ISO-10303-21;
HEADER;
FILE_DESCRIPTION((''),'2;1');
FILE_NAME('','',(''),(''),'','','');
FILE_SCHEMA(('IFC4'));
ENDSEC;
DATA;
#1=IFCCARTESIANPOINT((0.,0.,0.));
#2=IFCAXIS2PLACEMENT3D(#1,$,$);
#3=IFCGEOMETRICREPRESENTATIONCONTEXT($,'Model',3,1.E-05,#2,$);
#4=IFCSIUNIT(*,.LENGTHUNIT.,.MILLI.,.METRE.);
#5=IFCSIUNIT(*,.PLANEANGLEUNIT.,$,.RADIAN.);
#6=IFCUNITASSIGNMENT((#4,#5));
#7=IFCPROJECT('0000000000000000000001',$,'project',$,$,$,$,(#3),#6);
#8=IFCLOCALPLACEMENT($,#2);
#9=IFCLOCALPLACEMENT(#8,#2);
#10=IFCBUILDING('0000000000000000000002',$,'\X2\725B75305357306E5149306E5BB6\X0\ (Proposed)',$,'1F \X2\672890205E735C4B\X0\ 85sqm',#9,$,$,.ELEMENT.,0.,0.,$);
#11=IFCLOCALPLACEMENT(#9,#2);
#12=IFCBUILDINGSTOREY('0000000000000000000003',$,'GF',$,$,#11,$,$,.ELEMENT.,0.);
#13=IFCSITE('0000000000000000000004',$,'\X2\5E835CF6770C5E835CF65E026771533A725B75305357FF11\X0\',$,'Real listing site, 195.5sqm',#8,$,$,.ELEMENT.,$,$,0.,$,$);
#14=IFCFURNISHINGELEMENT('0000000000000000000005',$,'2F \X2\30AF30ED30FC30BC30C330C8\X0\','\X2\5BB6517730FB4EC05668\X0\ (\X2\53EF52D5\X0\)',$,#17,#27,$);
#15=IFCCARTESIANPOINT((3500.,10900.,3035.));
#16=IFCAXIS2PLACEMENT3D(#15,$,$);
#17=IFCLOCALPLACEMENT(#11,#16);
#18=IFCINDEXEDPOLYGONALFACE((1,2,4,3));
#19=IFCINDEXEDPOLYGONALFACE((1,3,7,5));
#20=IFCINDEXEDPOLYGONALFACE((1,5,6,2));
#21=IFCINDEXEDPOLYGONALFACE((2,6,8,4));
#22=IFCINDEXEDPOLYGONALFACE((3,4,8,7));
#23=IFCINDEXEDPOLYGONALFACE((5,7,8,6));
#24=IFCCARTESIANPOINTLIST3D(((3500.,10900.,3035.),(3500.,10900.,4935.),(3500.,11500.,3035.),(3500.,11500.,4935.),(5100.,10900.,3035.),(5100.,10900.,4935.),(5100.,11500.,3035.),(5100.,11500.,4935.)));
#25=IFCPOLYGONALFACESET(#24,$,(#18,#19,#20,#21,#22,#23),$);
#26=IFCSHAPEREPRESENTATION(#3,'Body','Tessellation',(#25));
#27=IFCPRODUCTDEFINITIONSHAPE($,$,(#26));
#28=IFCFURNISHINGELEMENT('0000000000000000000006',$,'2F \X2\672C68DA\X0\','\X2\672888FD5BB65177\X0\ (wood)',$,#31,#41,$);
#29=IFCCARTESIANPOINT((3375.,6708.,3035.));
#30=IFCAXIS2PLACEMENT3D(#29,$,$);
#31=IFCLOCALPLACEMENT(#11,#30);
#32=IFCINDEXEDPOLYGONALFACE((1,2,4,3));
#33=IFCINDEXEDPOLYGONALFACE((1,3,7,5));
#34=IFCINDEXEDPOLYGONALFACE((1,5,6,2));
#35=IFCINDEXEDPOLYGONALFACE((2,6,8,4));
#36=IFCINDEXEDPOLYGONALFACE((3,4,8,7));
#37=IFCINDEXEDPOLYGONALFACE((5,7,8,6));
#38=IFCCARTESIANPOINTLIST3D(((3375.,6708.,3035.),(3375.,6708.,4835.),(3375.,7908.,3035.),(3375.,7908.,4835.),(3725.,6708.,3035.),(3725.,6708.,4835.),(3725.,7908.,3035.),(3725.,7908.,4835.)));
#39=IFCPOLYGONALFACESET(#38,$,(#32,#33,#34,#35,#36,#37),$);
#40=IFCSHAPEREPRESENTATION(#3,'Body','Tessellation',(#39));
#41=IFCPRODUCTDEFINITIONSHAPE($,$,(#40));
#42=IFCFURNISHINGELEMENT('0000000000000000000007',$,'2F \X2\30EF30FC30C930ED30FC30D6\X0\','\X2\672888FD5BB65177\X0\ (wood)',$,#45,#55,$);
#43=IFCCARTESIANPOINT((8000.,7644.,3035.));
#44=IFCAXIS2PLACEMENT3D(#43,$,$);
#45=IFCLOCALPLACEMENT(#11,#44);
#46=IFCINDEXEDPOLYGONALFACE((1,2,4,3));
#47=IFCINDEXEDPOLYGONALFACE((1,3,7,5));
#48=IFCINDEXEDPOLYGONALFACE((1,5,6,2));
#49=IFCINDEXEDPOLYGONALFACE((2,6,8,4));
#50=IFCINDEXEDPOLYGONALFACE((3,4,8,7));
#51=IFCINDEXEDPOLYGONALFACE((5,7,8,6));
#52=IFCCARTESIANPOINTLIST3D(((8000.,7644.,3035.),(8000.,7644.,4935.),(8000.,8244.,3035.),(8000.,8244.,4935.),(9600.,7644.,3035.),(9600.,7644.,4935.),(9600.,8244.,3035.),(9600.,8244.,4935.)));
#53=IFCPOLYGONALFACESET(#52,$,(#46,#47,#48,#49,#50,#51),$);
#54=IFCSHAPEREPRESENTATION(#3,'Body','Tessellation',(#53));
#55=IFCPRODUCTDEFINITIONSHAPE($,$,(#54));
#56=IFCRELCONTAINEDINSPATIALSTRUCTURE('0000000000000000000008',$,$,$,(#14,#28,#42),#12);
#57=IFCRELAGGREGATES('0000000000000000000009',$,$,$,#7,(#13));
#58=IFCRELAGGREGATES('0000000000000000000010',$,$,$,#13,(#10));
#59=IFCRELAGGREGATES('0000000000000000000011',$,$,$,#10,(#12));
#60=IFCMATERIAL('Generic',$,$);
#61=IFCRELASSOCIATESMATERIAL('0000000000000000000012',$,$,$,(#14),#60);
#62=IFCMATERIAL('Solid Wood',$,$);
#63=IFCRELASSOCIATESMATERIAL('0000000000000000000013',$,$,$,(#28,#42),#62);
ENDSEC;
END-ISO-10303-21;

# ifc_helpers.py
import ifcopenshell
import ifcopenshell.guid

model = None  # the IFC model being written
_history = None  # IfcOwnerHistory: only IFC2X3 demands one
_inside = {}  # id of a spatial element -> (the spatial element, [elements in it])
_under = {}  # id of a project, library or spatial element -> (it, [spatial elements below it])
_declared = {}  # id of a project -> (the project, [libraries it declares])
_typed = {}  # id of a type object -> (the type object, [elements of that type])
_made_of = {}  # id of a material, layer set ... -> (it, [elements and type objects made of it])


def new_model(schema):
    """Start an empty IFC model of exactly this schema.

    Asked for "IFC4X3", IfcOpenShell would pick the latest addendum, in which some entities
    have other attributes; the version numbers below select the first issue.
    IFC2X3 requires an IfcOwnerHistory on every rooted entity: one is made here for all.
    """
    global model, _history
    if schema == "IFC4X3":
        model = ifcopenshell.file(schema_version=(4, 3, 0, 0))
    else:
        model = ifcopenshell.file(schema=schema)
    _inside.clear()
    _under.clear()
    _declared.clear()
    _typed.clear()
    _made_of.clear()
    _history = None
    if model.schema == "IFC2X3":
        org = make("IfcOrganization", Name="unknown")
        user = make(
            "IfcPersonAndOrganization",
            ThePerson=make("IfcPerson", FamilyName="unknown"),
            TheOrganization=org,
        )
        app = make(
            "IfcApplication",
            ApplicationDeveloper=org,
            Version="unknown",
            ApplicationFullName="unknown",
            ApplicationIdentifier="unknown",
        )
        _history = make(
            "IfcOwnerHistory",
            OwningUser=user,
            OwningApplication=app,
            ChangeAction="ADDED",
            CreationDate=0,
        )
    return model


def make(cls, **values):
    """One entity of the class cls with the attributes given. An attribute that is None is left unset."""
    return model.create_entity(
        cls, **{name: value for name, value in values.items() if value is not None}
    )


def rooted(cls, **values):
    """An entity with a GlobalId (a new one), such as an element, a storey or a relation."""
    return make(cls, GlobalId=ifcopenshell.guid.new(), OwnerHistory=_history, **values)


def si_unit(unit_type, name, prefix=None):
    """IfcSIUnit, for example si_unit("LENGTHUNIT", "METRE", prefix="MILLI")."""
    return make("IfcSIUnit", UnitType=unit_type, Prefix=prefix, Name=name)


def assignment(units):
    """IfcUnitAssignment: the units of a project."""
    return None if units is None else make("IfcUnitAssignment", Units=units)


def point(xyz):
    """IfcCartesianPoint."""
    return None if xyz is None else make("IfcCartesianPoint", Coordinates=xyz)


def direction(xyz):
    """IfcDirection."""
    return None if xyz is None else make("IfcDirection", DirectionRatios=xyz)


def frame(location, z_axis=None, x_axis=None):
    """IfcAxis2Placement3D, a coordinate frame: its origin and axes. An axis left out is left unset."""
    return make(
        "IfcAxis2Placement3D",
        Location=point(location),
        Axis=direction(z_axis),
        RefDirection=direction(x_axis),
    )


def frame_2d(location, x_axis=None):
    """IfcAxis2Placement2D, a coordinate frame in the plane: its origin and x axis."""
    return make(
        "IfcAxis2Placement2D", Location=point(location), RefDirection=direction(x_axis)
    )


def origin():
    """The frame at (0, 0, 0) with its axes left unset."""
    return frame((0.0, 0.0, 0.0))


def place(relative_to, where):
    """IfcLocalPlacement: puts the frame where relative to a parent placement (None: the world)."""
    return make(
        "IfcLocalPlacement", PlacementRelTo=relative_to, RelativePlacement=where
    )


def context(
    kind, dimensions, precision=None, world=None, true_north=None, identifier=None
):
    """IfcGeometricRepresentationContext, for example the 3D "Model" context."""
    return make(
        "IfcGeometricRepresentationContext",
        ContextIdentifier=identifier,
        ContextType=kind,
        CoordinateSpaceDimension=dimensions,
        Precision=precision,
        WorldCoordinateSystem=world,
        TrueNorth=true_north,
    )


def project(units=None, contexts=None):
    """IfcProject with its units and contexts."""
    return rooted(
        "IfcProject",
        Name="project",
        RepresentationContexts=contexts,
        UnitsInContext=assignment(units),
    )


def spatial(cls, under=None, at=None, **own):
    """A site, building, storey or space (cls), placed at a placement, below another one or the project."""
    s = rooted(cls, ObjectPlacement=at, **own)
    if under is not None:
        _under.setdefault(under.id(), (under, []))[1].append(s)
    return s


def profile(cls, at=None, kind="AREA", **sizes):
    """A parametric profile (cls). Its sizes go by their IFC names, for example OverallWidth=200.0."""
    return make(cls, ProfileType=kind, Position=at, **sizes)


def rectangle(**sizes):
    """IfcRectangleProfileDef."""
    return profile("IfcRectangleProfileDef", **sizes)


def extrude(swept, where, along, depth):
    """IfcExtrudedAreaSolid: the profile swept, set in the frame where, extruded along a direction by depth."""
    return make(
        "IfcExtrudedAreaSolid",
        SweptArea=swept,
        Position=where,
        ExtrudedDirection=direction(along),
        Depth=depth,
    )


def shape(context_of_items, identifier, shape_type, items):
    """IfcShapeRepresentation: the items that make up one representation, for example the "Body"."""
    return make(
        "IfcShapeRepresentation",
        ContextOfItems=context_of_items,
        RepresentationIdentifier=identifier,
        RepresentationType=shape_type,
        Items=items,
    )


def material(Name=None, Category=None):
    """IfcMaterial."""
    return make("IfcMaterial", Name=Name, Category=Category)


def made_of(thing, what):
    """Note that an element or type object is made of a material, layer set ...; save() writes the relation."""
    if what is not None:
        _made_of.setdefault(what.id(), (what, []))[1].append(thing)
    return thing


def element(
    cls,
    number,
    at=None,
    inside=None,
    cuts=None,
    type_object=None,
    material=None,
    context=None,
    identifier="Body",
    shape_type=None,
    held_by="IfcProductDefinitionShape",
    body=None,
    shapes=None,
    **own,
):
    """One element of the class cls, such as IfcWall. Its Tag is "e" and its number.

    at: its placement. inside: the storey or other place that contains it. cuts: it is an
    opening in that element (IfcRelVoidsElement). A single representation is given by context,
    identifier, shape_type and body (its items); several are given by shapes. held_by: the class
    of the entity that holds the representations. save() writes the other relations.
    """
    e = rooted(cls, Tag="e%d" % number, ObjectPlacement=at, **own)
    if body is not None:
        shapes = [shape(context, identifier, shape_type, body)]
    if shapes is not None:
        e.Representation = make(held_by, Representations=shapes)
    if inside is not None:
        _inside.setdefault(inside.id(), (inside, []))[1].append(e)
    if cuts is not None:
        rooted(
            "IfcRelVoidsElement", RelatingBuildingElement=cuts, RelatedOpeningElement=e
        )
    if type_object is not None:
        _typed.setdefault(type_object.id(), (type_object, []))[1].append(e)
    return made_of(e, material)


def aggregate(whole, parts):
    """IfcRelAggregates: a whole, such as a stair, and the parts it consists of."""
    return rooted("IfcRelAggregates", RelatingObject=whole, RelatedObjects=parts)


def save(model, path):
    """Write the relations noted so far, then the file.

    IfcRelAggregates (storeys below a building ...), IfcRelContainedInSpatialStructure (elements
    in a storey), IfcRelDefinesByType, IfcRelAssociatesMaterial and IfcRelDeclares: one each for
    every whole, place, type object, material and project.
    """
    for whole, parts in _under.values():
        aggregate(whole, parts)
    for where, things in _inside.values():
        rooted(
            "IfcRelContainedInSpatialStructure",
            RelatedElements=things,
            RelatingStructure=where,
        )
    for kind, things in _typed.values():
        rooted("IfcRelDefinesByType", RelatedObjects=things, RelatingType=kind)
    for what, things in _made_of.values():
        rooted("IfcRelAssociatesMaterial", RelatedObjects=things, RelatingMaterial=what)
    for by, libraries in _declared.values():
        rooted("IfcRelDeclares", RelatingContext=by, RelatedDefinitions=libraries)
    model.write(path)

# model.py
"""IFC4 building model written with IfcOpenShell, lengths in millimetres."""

from ifc_helpers import new_model, si_unit, frame, frame_2d, origin, place, context, project, spatial, rectangle, extrude, material, element, save


model = new_model("IFC4")

# Units and contexts
model_context = context("Model", 3, precision=1e-05, world=origin())
ifc_project = project(units=[si_unit("LENGTHUNIT", "METRE", prefix="MILLI"), si_unit("PLANEANGLEUNIT", "RADIAN")], contexts=[model_context])

# Site, building, storey
site_placement = place(None, origin())
site = spatial("IfcSite", under=ifc_project, at=site_placement, Name="広島県広島市東区牛田南１", ObjectType="Real listing site, 195.5sqm", CompositionType="ELEMENT", RefElevation=0.0)
building_placement = place(site_placement, origin())
building = spatial("IfcBuilding", under=site, at=building_placement, Name="牛田南の光の家 (Proposed)", ObjectType="1F 木造平屋 85sqm", CompositionType="ELEMENT", ElevationOfRefHeight=0.0, ElevationOfTerrain=0.0)
storey_placement = place(building_placement, origin())
storey = spatial("IfcBuildingStorey", under=building, at=storey_placement, Name="GF", CompositionType="ELEMENT", Elevation=0.0)

# Shared definitions
ifc_material_1 = material(Name="Solid Wood")

# Shared definitions
ifc_material_2 = material(Name="Generic")

# Furnishing elements
furnishing_1_placement = place(storey_placement, frame((3500.0, 10900.0, 3035.0)))
element("IfcFurnishingElement", 1, at=furnishing_1_placement, inside=storey, material=ifc_material_2, Name="2F クローゼット", Description="家具・什器 (可動)", context=model_context, shape_type="SweptSolid", body=[
    extrude(rectangle(XDim=1600.0, YDim=600.0, at=frame_2d((800.0, 300.0))), frame((3500.0, 10900.0, 3035.0)), (0.0, 0.0, 1.0), 1900.0),
])
furnishing_2_placement = place(storey_placement, frame((3375.0, 6708.0, 3035.0)))
element("IfcFurnishingElement", 2, at=furnishing_2_placement, inside=storey, material=ifc_material_1, Name="2F 本棚", Description="木製家具 (wood)", context=model_context, shape_type="SweptSolid", body=[
    extrude(rectangle(XDim=350.0, YDim=1200.0, at=frame_2d((175.0, 600.0))), frame((3375.0, 6708.0, 3035.0)), (0.0, 0.0, 1.0), 1800.0),
])
furnishing_3_placement = place(storey_placement, frame((8000.0, 7644.0, 3035.0)))
element("IfcFurnishingElement", 3, at=furnishing_3_placement, inside=storey, material=ifc_material_1, Name="2F ワードローブ", Description="木製家具 (wood)", context=model_context, shape_type="SweptSolid", body=[
    extrude(rectangle(XDim=1600.0, YDim=600.0, at=frame_2d((800.0, 300.0))), frame((8000.0, 7644.0, 3035.0)), (0.0, 0.0, 1.0), 1900.0),
])

save(model, "model.ifc")
